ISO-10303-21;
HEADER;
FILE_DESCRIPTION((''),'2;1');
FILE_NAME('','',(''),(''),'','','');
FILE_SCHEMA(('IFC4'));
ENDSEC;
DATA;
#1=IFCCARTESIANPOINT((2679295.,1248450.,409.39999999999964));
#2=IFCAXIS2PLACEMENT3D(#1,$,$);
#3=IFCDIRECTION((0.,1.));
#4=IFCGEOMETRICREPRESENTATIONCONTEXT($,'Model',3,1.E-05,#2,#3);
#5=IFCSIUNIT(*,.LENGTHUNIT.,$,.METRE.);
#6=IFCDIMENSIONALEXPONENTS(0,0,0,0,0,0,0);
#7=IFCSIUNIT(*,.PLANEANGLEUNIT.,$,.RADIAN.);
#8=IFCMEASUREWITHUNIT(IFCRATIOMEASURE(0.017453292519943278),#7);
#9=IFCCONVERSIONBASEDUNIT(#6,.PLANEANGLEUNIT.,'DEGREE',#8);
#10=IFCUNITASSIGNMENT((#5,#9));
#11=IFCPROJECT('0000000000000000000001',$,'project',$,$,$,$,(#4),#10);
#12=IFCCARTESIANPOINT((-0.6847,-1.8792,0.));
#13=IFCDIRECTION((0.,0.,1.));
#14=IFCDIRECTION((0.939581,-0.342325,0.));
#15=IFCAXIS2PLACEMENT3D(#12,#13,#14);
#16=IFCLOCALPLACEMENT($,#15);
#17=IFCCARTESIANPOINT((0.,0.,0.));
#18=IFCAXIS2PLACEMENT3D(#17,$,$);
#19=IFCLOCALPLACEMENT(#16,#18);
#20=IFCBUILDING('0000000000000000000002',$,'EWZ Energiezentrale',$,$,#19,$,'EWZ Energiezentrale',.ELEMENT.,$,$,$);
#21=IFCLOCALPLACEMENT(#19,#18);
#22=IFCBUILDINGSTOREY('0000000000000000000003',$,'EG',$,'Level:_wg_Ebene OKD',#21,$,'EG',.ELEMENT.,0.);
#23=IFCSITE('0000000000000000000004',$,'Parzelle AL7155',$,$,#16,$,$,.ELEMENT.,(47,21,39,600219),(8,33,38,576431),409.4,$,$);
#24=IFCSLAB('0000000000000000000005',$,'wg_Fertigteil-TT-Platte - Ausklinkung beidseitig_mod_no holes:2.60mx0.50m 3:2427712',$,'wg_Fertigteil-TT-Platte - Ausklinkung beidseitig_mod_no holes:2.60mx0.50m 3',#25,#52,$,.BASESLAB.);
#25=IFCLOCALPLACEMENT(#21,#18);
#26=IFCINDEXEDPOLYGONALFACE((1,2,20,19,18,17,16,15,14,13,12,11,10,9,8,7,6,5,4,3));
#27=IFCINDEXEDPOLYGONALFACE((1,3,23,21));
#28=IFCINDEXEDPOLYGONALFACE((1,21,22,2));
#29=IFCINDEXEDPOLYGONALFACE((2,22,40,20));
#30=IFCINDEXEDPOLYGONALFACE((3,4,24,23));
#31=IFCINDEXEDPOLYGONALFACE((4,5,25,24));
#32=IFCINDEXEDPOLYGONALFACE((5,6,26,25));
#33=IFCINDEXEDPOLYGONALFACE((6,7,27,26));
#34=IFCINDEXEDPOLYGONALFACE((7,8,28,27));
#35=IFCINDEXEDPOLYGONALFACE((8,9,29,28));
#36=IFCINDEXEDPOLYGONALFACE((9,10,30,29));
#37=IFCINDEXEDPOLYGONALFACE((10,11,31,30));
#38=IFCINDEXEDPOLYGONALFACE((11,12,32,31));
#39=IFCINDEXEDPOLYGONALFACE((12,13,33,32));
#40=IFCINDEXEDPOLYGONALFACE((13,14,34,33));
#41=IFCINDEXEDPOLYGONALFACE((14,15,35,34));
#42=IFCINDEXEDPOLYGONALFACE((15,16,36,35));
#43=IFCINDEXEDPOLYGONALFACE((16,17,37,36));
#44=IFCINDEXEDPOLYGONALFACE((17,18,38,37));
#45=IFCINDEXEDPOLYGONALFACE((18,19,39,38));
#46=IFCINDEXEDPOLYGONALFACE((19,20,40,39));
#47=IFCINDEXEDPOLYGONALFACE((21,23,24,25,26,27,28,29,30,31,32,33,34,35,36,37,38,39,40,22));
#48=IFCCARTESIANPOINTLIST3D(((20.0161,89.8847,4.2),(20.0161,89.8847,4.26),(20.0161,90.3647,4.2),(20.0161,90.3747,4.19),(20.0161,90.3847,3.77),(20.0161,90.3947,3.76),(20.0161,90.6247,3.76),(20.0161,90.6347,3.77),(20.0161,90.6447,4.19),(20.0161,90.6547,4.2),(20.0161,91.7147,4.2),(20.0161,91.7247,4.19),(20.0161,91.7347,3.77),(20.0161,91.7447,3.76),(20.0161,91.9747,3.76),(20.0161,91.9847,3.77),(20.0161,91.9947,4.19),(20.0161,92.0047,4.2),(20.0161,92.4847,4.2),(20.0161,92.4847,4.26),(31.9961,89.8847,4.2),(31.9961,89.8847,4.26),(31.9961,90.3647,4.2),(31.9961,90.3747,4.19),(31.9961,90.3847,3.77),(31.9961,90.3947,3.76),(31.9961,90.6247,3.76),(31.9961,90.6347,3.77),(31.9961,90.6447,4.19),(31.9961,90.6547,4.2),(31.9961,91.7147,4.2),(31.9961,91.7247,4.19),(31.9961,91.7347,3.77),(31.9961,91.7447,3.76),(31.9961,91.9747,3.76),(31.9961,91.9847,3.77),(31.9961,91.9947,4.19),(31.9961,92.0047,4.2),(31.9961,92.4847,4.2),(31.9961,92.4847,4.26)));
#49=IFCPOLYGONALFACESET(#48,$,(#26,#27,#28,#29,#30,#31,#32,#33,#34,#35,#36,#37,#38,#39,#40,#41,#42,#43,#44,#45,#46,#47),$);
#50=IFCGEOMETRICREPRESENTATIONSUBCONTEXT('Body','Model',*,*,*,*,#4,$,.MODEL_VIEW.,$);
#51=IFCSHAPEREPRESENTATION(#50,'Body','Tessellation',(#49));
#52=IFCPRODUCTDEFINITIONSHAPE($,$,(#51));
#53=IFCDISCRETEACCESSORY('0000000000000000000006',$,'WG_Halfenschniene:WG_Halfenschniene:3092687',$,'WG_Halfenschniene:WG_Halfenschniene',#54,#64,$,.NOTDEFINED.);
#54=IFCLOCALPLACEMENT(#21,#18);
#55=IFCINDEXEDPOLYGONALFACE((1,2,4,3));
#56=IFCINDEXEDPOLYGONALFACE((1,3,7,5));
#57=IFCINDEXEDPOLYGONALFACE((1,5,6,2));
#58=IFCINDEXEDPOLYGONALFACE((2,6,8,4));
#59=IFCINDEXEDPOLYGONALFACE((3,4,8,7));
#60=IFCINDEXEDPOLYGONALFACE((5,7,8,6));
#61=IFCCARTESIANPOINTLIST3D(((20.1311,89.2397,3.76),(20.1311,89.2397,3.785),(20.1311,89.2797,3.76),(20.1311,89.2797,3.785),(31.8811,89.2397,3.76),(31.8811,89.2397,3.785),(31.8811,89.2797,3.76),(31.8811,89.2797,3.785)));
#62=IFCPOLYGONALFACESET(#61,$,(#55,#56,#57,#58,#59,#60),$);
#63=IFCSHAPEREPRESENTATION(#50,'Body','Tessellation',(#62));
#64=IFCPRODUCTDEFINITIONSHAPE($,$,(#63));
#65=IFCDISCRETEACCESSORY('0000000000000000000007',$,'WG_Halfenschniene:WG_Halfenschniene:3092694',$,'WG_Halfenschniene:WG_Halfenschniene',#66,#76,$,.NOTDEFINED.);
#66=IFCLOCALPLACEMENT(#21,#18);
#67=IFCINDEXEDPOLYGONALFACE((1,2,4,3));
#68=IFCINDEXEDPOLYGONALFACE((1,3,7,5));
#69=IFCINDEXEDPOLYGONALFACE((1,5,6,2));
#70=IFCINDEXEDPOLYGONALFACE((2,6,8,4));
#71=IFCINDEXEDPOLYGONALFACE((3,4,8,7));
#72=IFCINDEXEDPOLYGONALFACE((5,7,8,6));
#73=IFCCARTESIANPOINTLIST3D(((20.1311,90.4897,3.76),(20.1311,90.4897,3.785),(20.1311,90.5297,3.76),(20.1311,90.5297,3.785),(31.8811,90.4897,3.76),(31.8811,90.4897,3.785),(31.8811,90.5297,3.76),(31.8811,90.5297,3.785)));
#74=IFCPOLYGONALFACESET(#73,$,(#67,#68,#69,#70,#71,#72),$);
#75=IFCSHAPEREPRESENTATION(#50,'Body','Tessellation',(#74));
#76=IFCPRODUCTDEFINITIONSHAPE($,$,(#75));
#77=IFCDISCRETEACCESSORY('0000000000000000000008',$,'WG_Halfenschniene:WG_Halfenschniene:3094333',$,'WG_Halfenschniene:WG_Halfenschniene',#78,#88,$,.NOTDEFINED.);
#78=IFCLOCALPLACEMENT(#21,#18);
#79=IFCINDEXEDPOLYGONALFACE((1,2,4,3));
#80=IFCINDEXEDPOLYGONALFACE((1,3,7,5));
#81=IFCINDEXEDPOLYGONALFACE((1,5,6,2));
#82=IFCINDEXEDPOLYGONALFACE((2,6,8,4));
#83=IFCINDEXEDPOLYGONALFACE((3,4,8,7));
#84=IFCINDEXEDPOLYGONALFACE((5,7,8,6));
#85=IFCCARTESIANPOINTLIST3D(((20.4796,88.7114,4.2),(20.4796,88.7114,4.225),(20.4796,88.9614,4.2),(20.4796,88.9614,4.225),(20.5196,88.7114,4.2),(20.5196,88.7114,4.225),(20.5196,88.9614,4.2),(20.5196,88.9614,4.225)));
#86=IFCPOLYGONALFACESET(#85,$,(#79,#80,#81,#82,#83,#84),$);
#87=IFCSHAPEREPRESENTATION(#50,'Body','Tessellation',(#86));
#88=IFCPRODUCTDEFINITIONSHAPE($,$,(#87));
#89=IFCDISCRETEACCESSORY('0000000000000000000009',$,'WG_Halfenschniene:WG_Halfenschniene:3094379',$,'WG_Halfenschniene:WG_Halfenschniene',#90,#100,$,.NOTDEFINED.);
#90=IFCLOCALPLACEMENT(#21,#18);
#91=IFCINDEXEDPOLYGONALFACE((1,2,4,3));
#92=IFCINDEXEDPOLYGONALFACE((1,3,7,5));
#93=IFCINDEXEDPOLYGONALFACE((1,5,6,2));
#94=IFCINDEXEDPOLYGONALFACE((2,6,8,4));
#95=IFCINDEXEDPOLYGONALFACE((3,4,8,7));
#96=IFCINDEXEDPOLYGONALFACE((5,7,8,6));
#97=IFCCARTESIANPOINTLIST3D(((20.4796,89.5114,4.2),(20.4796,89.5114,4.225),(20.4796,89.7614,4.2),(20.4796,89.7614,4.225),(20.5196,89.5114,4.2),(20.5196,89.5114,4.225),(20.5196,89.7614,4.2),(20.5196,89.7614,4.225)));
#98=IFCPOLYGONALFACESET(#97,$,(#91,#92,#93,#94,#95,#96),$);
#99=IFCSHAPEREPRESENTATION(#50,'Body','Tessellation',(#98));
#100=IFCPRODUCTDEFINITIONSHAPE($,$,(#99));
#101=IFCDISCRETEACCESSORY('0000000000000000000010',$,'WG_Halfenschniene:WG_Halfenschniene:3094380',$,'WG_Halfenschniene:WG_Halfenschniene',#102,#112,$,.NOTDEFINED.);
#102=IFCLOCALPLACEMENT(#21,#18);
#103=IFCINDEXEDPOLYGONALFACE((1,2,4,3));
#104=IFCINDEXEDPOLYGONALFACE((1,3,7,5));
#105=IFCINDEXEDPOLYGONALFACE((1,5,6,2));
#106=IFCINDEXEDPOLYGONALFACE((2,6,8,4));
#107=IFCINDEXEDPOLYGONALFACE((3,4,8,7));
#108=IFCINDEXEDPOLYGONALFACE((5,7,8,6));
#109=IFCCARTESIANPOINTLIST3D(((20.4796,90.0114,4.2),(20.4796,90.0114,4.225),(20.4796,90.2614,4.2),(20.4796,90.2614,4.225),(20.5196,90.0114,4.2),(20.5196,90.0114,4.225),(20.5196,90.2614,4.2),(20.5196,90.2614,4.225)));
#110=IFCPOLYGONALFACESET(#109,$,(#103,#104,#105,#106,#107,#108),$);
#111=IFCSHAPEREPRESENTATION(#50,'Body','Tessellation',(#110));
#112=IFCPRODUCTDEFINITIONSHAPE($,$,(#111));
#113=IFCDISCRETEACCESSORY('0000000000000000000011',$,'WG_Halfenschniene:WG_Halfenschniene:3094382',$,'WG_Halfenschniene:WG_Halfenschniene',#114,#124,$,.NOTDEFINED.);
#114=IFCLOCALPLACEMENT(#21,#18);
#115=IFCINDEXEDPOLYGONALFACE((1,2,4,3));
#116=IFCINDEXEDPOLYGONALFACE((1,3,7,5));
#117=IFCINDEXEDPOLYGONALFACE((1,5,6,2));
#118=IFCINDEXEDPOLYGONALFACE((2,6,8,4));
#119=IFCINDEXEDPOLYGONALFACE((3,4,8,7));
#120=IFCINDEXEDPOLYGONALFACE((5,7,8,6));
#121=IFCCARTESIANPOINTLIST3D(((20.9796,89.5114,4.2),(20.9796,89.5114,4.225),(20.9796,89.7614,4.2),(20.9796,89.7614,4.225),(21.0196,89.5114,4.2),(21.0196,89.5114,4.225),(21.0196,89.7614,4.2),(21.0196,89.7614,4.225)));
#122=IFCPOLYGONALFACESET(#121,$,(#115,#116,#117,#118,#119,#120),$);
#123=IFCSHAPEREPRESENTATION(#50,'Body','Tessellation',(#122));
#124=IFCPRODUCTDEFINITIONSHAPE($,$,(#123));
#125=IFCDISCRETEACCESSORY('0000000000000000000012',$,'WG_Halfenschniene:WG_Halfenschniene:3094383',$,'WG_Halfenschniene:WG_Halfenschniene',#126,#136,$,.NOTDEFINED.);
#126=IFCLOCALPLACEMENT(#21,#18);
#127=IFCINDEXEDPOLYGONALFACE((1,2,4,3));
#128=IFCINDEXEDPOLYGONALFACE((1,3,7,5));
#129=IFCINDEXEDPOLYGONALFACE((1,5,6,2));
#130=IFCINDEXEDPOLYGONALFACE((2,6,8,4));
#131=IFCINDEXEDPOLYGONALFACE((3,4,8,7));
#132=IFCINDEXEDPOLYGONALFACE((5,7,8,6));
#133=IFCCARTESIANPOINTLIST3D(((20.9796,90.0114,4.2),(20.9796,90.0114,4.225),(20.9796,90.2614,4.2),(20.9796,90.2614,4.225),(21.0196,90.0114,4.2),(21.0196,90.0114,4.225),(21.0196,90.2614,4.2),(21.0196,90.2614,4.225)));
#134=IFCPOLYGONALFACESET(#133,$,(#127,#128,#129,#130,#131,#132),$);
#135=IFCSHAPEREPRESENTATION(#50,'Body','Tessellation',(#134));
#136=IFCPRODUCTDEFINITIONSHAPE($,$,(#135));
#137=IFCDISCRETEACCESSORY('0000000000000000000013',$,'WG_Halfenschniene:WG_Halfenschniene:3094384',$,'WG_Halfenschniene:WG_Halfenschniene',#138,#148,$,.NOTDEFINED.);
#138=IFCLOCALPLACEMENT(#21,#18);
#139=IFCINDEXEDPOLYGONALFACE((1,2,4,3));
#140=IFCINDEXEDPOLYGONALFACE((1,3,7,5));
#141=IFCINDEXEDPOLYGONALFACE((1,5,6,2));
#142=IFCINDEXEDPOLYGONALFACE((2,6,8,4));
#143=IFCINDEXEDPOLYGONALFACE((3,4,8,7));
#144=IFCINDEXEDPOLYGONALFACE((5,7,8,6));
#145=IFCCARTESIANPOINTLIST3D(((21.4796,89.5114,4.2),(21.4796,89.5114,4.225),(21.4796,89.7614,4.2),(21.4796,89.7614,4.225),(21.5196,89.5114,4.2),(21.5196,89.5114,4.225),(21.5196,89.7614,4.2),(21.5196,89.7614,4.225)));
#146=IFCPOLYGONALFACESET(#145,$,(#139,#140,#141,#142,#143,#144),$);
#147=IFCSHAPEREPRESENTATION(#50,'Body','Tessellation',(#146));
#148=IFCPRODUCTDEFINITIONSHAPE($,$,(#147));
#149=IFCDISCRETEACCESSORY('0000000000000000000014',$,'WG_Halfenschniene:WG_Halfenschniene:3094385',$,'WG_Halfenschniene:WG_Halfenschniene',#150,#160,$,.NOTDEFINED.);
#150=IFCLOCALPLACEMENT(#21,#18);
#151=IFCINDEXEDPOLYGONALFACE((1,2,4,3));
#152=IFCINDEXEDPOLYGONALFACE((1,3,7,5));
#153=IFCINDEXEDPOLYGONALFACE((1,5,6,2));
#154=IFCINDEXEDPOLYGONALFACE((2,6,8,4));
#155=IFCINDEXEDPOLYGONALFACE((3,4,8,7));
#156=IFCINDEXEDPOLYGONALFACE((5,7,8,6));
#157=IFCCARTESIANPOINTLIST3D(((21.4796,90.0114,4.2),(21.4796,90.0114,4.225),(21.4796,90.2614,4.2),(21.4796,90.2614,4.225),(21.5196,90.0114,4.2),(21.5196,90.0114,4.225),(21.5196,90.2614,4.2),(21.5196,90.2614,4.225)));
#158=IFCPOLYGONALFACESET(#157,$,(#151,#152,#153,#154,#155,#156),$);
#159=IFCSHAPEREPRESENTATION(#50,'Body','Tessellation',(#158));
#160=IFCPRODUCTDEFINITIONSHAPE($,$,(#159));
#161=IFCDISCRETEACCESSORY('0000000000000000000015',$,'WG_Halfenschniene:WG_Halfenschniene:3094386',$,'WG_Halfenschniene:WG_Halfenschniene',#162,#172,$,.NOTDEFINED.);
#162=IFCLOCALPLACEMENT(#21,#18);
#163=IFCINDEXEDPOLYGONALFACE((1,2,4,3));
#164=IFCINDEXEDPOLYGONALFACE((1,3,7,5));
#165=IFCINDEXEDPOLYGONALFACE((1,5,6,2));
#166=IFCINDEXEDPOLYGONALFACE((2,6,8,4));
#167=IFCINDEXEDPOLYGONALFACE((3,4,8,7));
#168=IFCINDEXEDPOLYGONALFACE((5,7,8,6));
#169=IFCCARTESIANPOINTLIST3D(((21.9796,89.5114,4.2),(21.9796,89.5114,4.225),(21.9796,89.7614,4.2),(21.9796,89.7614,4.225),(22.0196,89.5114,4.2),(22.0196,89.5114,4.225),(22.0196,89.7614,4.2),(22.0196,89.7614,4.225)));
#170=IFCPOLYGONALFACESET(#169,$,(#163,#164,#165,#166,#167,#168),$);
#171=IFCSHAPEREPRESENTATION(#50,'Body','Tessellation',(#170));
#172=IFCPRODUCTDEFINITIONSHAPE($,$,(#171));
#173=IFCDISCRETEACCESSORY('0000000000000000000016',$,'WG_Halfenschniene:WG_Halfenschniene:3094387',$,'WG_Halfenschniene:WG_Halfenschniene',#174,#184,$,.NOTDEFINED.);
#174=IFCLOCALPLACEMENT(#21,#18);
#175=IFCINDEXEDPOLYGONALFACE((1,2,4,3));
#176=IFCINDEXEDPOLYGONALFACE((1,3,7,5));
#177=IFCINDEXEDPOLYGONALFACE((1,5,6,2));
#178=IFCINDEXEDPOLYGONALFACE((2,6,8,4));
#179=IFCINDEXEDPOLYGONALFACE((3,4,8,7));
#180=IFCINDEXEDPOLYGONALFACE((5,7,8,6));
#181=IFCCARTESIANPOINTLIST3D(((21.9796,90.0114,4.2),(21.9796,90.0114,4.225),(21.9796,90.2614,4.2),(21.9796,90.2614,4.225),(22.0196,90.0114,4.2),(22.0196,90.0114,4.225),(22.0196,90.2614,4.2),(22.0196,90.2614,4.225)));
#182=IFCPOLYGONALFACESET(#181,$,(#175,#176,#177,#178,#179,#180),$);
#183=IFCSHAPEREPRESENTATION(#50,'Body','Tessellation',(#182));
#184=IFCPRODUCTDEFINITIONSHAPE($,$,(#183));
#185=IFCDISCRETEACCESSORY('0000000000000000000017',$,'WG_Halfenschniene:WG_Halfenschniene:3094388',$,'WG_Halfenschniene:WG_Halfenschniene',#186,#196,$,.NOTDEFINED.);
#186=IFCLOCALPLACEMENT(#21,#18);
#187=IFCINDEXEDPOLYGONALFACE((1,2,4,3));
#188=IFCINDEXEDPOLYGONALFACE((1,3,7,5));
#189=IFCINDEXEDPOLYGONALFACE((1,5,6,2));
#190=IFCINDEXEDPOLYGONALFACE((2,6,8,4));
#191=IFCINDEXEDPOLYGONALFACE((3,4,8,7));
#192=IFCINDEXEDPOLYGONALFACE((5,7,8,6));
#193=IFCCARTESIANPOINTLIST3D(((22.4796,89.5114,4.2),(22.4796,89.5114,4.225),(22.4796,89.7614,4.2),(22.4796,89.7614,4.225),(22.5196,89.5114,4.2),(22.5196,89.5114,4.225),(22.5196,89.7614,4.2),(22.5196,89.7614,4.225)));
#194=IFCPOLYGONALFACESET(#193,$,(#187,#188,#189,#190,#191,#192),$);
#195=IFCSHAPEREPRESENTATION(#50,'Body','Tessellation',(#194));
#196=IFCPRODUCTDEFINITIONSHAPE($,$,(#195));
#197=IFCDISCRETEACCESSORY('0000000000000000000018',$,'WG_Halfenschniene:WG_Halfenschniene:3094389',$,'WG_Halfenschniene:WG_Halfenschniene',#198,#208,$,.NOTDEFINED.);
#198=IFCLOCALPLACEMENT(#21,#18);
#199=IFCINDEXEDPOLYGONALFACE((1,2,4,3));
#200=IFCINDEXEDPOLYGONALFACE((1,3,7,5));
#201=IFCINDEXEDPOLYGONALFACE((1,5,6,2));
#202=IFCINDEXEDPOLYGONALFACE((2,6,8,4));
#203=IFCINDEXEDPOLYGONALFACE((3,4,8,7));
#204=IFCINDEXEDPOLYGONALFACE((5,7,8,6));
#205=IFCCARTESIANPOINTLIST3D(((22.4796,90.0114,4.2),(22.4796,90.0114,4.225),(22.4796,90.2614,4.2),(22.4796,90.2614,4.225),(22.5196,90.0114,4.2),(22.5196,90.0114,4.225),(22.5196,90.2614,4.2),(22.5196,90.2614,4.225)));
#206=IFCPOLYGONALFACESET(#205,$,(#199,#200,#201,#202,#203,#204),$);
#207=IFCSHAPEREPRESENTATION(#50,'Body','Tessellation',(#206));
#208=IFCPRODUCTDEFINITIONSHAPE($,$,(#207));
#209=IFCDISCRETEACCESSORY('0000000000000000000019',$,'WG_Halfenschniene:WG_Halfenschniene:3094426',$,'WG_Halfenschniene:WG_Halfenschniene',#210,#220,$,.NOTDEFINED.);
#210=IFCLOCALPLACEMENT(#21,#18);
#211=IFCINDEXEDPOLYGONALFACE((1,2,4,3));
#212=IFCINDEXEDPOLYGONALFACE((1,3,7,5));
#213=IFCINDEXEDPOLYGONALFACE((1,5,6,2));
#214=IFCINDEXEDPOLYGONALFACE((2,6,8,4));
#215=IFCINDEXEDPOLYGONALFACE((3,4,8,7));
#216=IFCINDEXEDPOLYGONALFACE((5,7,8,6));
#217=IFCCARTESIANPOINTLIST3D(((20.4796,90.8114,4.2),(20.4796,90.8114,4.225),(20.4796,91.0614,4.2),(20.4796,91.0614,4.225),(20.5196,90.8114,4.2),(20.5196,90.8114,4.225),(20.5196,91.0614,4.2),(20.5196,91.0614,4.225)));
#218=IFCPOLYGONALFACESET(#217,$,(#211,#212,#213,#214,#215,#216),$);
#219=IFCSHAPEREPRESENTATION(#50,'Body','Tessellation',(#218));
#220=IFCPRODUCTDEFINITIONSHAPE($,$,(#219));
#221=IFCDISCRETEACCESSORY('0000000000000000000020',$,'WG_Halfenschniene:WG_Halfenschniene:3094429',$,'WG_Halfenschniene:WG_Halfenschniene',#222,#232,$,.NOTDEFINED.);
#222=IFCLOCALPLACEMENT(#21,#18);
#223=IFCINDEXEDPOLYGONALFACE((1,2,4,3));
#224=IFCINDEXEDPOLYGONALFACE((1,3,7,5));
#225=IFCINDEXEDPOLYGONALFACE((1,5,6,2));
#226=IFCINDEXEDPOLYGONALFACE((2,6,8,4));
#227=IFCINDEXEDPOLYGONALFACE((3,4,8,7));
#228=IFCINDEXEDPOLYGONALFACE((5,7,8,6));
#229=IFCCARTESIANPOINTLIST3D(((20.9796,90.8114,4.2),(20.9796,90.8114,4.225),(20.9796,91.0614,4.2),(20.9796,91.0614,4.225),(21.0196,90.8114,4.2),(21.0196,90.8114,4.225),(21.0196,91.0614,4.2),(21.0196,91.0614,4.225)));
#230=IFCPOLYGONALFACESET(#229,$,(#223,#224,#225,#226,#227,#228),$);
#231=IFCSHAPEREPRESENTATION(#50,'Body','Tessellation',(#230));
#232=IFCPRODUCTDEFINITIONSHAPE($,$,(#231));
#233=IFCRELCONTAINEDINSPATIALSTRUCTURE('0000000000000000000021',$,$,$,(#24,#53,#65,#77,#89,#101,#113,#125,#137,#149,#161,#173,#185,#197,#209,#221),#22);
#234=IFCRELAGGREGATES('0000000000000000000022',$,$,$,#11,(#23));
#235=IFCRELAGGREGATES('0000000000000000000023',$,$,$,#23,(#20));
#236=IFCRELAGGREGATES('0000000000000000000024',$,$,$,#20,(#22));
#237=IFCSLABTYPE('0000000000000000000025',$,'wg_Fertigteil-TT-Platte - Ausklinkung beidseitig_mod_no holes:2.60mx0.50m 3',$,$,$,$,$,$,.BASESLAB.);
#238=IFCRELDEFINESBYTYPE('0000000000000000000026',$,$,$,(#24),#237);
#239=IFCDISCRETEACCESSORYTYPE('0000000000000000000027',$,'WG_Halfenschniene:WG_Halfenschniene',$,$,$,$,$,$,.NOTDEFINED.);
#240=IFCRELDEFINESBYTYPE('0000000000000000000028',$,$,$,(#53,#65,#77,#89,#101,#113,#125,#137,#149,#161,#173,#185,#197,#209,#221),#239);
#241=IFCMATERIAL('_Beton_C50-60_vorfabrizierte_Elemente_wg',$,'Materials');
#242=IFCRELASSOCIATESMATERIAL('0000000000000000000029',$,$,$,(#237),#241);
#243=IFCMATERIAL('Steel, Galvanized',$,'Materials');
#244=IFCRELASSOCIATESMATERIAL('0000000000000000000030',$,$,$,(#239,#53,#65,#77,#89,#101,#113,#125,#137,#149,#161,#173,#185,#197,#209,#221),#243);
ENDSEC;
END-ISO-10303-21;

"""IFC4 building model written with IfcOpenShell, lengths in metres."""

from ifc_helpers import new_model, entity, si_unit, converted_unit, direction, frame, origin, place, context, subcontext, project, spatial, indexed_curve, outline, extrude, source, transform, mapped, material, type_object, type_shapes, element, save


model = new_model("IFC4")

# Units and contexts
model_context = context("Model", 3, precision=1e-05, world=frame((2679295.0, 1248450.0, 409.39999999999964)), true_north=direction((0.0, 1.0)))
body_context = subcontext(model_context, "Body", "Model", "MODEL_VIEW")
ifc_project = project(units=[si_unit("LENGTHUNIT", "METRE"), converted_unit("PLANEANGLEUNIT", "DEGREE", entity("IfcRatioMeasure", 0.017453292519943278), si_unit("PLANEANGLEUNIT", "RADIAN"), dimensions=[0, 0, 0, 0, 0, 0, 0])], contexts=[model_context])

# Site, building, storey
site_placement = place(None, frame((-0.6847, -1.8792, 0.0), z_axis=(0.0, 0.0, 1.0), x_axis=(0.939581, -0.342325, 0.0)))
site = spatial("IfcSite", under=ifc_project, at=site_placement, Name="Parzelle AL7155", CompositionType="ELEMENT", RefLatitude=(47, 21, 39, 600219), RefLongitude=(8, 33, 38, 576431), RefElevation=409.4)
building_placement = place(site_placement, origin())
building = spatial("IfcBuilding", under=site, at=building_placement, Name="EWZ Energiezentrale", LongName="EWZ Energiezentrale", CompositionType="ELEMENT")
storey_placement = place(building_placement, origin())
storey = spatial("IfcBuildingStorey", under=building, at=storey_placement, Name="EG", ObjectType="Level:_wg_Ebene OKD", LongName="EG", CompositionType="ELEMENT", Elevation=0.0)

# Slab
ifc_material_1 = material(Name="_Beton_C50-60_vorfabrizierte_Elemente_wg", Category="Materials")
slab_type = type_object("IfcSlabType", Name="wg_Fertigteil-TT-Platte - Ausklinkung beidseitig_mod_no holes:2.60mx0.50m 3", PredefinedType="BASESLAB", material=ifc_material_1)
slab_placement = place(storey_placement, frame((20.0161, 89.8847, 3.76), z_axis=(0.0, 0.0, 1.0), x_axis=(1.0, 0.0, 0.0)))
element("IfcSlab", 1, at=slab_placement, inside=storey, type_object=slab_type, Name="wg_Fertigteil-TT-Platte - Ausklinkung beidseitig_mod_no holes:2.60mx0.50m 3:2427712", ObjectType="wg_Fertigteil-TT-Platte - Ausklinkung beidseitig_mod_no holes:2.60mx0.50m 3", PredefinedType="BASESLAB", context=body_context, shape_type="SweptSolid", body=[
    extrude(outline(indexed_curve([(-1.3, -0.23), (1.3, -0.23), (1.3, -0.17), (0.82, -0.17), (0.81, -0.16), (0.8, 0.26), (0.79, 0.27), (0.56, 0.27), (0.55, 0.26), (0.54, -0.16), (0.53, -0.17), (-0.53, -0.17), (-0.54, -0.16), (-0.55, 0.26), (-0.56, 0.27), (-0.79, 0.27), (-0.8, 0.26), (-0.81, -0.16), (-0.82, -0.17), (-1.3, -0.17), (-1.3, -0.23)], self_intersect=False)), frame((0.0, 1.3, 0.27), z_axis=(1.0, 0.0, 0.0), x_axis=(0.0, -1.0, 0.0)), (0.0, 0.0, 1.0), 11.98),
])

# Discrete accessories
ifc_material_2 = material(Name="Steel, Galvanized", Category="Materials")
discrete_accessory_type = type_object("IfcDiscreteAccessoryType", Name="WG_Halfenschniene:WG_Halfenschniene", PredefinedType="NOTDEFINED", material=ifc_material_2)
shared_shape_1 = source(origin(), body_context, "Body", "SweptSolid", [
    extrude(outline(indexed_curve([(-5.875, -0.02), (5.875, -0.02), (5.875, 0.02), (-5.875, 0.02), (-5.875, -0.02)], self_intersect=False)), frame((5.875, 0.0, -0.0125)), (0.0, 0.0, 1.0), 0.025),
])
type_shapes(discrete_accessory_type, [shared_shape_1])
for number, where, z_axis, x_axis, name in (
    (2, (20.1311, 89.2597, 3.7725), (0.0, 0.0, -1.0), (1.0, 0.0, 0.0), "WG_Halfenschniene:WG_Halfenschniene:3092687"),
    (3, (20.1311, 90.5097, 3.7725), (0.0, 0.0, -1.0), (1.0, 0.0, 0.0), "WG_Halfenschniene:WG_Halfenschniene:3092694"),
):
    element("IfcDiscreteAccessory", number, at=place(storey_placement, frame(where, z_axis=z_axis, x_axis=x_axis)), inside=storey, type_object=discrete_accessory_type, material=ifc_material_2, Name=name, ObjectType="WG_Halfenschniene:WG_Halfenschniene", PredefinedType="NOTDEFINED", context=body_context, shape_type="MappedRepresentation", body=[
        mapped(shared_shape_1, transform((0.0, 0.0, 0.0), scale=1.0)),
    ])
shared_shape_2 = source(origin(), body_context, "Body", "SweptSolid", [
    extrude(outline(indexed_curve([(-0.125, -0.02), (0.125, -0.02), (0.125, 0.02), (-0.125, 0.02), (-0.125, -0.02)], self_intersect=False)), frame((0.125, 0.0, -0.0125)), (0.0, 0.0, 1.0), 0.025),
])
for number, where, z_axis, x_axis, name in (
    (4, (20.4996, 88.7114, 4.2125), (0.0, 0.0, -1.0), (0.0, 1.0, 0.0), "WG_Halfenschniene:WG_Halfenschniene:3094333"),
    (5, (20.4996, 89.5114, 4.2125), (0.0, 0.0, -1.0), (0.0, 1.0, 0.0), "WG_Halfenschniene:WG_Halfenschniene:3094379"),
    (6, (20.4996, 90.0114, 4.2125), (0.0, 0.0, -1.0), (0.0, 1.0, 0.0), "WG_Halfenschniene:WG_Halfenschniene:3094380"),
    (7, (20.9996, 89.5114, 4.2125), (0.0, 0.0, -1.0), (0.0, 1.0, 0.0), "WG_Halfenschniene:WG_Halfenschniene:3094382"),
    (8, (20.9996, 90.0114, 4.2125), (0.0, 0.0, -1.0), (0.0, 1.0, 0.0), "WG_Halfenschniene:WG_Halfenschniene:3094383"),
    (9, (21.4996, 89.5114, 4.2125), (0.0, 0.0, -1.0), (0.0, 1.0, 0.0), "WG_Halfenschniene:WG_Halfenschniene:3094384"),
    (10, (21.4996, 90.0114, 4.2125), (0.0, 0.0, -1.0), (0.0, 1.0, 0.0), "WG_Halfenschniene:WG_Halfenschniene:3094385"),
    (11, (21.9996, 89.5114, 4.2125), (0.0, 0.0, -1.0), (0.0, 1.0, 0.0), "WG_Halfenschniene:WG_Halfenschniene:3094386"),
    (12, (21.9996, 90.0114, 4.2125), (0.0, 0.0, -1.0), (0.0, 1.0, 0.0), "WG_Halfenschniene:WG_Halfenschniene:3094387"),
    (13, (22.4996, 89.5114, 4.2125), (0.0, 0.0, -1.0), (0.0, 1.0, 0.0), "WG_Halfenschniene:WG_Halfenschniene:3094388"),
    (14, (22.4996, 90.0114, 4.2125), (0.0, 0.0, -1.0), (0.0, 1.0, 0.0), "WG_Halfenschniene:WG_Halfenschniene:3094389"),
    (15, (20.4996, 90.8114, 4.2125), (0.0, 0.0, -1.0), (0.0, 1.0, 0.0), "WG_Halfenschniene:WG_Halfenschniene:3094426"),
    (16, (20.9996, 90.8114, 4.2125), (0.0, 0.0, -1.0), (0.0, 1.0, 0.0), "WG_Halfenschniene:WG_Halfenschniene:3094429"),
):
    element("IfcDiscreteAccessory", number, at=place(storey_placement, frame(where, z_axis=z_axis, x_axis=x_axis)), inside=storey, type_object=discrete_accessory_type, material=ifc_material_2, Name=name, ObjectType="WG_Halfenschniene:WG_Halfenschniene", PredefinedType="NOTDEFINED", context=body_context, shape_type="MappedRepresentation", body=[
        mapped(shared_shape_2, transform((0.0, 0.0, 0.0), scale=1.0)),
    ])

save(model, "model.ifc")
